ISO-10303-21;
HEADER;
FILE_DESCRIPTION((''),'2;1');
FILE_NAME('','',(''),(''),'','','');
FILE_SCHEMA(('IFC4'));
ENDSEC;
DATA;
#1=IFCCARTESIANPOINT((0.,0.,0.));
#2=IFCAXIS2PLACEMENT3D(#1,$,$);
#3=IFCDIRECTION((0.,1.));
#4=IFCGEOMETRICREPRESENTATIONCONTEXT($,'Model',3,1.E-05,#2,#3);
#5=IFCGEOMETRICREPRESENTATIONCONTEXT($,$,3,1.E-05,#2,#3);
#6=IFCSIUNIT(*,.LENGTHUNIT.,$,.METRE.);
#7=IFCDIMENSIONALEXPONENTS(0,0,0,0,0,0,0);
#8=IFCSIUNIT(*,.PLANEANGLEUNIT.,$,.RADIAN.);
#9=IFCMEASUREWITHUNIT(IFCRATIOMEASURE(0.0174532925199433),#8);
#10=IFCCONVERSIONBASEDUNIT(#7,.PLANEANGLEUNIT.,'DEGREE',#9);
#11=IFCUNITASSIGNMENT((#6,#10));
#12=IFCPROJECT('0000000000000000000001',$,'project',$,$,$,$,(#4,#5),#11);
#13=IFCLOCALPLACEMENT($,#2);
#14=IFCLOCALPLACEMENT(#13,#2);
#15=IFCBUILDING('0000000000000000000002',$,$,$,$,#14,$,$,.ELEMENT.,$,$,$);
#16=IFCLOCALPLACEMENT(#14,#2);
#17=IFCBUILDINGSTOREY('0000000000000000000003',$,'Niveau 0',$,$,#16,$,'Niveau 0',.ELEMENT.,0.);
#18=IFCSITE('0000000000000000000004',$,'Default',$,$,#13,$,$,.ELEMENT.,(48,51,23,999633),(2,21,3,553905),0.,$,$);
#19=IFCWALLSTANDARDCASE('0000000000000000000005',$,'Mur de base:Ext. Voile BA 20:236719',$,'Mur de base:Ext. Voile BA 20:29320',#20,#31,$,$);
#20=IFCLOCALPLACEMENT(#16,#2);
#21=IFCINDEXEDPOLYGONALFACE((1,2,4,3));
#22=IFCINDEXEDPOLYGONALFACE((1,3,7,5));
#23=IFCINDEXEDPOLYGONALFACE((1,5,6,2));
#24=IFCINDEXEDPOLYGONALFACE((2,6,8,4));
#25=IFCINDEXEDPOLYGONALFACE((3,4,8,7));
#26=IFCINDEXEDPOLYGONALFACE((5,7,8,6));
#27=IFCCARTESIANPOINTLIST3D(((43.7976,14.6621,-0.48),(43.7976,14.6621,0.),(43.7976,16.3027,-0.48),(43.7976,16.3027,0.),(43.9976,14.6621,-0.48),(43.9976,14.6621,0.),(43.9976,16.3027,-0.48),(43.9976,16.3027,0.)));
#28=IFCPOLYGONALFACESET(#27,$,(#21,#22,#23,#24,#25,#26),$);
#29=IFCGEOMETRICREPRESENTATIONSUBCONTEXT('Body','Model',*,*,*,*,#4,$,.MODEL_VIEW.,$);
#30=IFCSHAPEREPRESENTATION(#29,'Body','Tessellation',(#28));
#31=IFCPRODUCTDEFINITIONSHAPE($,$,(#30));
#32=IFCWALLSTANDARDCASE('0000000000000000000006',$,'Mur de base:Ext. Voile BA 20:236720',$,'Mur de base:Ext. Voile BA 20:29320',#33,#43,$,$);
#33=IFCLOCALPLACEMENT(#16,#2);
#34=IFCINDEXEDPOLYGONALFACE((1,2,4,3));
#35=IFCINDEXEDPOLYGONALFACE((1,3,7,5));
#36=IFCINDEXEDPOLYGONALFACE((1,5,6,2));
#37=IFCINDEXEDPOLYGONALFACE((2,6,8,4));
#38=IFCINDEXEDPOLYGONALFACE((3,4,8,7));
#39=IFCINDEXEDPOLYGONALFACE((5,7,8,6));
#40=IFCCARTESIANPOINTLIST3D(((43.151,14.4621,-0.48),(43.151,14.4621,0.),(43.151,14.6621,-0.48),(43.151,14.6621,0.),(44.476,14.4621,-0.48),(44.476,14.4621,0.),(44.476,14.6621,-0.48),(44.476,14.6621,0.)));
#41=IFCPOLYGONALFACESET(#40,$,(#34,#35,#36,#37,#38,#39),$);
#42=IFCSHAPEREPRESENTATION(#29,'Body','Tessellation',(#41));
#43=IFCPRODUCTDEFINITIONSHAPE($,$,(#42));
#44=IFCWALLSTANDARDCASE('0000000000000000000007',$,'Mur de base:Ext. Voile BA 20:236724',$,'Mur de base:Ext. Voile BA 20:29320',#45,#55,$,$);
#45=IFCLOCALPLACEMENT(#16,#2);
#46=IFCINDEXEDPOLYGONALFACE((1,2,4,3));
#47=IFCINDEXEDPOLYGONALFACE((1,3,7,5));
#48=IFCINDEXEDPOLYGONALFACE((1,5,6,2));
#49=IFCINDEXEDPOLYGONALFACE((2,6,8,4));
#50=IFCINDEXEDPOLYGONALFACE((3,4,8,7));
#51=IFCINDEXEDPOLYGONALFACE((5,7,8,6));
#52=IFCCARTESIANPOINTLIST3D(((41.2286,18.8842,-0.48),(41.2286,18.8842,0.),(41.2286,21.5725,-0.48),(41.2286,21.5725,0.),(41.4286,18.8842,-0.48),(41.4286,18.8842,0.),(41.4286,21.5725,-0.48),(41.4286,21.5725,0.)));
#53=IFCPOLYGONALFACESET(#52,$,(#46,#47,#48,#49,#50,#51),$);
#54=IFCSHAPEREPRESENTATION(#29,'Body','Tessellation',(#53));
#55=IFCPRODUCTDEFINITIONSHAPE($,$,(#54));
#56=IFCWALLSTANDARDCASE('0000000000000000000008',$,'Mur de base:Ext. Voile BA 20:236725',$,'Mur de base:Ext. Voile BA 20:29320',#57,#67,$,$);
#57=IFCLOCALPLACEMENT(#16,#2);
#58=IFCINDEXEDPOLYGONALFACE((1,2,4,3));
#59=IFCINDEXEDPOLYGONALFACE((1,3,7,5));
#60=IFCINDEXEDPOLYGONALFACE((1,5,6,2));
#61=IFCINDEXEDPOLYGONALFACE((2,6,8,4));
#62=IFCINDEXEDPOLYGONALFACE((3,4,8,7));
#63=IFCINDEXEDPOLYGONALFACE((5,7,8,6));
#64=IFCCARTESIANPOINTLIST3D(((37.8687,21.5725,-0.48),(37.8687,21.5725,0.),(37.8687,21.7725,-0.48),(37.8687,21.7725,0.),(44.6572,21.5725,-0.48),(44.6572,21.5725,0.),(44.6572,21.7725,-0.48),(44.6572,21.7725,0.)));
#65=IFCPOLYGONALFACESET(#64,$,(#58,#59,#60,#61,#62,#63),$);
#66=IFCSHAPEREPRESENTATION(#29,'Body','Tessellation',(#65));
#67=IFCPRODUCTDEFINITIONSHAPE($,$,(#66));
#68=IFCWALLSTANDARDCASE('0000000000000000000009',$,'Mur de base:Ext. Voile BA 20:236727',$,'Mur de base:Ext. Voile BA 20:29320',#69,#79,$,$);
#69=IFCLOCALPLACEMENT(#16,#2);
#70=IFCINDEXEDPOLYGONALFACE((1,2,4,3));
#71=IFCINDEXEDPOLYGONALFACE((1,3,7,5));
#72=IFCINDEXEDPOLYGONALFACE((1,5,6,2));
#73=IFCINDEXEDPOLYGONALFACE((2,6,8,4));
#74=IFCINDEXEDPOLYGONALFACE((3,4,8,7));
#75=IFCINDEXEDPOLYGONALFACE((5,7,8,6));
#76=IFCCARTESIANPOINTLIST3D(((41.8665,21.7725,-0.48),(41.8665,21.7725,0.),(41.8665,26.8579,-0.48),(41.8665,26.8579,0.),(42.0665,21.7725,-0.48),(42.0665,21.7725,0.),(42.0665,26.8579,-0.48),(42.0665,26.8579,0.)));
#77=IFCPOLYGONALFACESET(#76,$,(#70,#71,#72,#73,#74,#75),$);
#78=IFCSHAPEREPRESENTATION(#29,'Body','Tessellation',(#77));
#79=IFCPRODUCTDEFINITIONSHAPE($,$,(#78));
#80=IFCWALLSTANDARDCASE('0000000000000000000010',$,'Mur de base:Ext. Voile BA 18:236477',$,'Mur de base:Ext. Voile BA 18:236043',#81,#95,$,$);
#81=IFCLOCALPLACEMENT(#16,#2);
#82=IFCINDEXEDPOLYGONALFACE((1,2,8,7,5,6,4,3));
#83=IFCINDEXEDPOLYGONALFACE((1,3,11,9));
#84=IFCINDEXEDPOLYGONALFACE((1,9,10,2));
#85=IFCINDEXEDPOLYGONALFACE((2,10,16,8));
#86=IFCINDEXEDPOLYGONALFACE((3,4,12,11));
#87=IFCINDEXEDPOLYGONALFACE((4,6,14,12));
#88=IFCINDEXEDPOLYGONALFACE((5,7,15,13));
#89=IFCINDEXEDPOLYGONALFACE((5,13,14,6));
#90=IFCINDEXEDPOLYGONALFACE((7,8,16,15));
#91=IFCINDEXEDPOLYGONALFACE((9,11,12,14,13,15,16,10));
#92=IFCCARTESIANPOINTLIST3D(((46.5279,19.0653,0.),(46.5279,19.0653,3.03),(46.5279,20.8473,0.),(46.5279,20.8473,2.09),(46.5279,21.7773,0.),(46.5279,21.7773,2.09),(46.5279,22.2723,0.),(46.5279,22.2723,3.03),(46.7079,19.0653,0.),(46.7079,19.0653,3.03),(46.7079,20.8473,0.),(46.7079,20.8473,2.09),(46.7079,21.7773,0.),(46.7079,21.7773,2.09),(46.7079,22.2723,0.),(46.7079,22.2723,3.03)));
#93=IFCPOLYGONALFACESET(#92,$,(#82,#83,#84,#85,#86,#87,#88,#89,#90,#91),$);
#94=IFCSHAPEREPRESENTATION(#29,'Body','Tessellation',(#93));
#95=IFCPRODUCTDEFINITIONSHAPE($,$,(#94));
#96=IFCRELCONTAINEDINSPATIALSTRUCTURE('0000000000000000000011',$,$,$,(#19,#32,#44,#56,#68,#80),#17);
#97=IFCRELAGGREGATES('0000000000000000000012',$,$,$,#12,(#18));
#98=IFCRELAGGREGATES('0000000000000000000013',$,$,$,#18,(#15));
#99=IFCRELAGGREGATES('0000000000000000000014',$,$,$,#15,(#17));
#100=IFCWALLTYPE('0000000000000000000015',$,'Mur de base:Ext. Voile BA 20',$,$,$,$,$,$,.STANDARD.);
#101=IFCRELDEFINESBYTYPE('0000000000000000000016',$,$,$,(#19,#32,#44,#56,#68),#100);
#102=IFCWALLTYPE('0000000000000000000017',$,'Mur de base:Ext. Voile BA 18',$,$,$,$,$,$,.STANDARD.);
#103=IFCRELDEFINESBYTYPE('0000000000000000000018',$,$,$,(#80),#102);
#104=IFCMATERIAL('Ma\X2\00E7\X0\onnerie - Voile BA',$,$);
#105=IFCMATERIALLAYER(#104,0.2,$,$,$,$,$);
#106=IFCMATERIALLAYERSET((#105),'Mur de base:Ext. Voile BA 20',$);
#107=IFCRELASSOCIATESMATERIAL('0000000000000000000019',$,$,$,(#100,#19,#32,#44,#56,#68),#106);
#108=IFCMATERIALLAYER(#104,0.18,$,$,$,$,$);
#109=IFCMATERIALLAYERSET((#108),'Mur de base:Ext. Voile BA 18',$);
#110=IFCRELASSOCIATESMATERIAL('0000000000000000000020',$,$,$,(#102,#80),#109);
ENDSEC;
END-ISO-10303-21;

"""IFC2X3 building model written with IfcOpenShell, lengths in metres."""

from ifc_helpers import new_model, entity, si_unit, converted_unit, direction, frame, frame_2d, origin, place, context, subcontext, project, spatial, rectangle, extrude, material, layer, layer_set, layer_usage, type_object, element, save


model = new_model("IFC2X3")

# Units and contexts
model_context = context("Model", 3, precision=1e-05, world=origin(), true_north=direction((0.0, 1.0)))
context_of_model = context(None, 3, precision=1e-05, world=origin(), true_north=direction((0.0, 1.0)))
body_context = subcontext(model_context, "Body", "Model", "MODEL_VIEW")
ifc_project = project(units=[si_unit("LENGTHUNIT", "METRE"), converted_unit("PLANEANGLEUNIT", "DEGREE", entity("IfcRatioMeasure", 0.0174532925199433), si_unit("PLANEANGLEUNIT", "RADIAN"), dimensions=[0, 0, 0, 0, 0, 0, 0])], contexts=[model_context, context_of_model])

# Site, building, storey
site_placement = place(None, origin())
site = spatial("IfcSite", under=ifc_project, at=site_placement, Name="Default", CompositionType="ELEMENT", RefLatitude=(48, 51, 23, 999633), RefLongitude=(2, 21, 3, 553905), RefElevation=0.0)
building_placement = place(site_placement, origin())
building = spatial("IfcBuilding", under=site, at=building_placement, CompositionType="ELEMENT")
storey_placement = place(building_placement, origin())
storey = spatial("IfcBuildingStorey", under=building, at=storey_placement, Name="Niveau 0", LongName="Niveau 0", CompositionType="ELEMENT", Elevation=0.0)

# Shared definitions
ifc_material = material(Name="Maçonnerie - Voile BA")
ifc_layer_1 = layer(ifc_material, 0.2)
ifc_layer_set_1 = layer_set([ifc_layer_1], Name="Mur de base:Ext. Voile BA 20")
wall_type_1 = type_object("IfcWallType", Name="Mur de base:Ext. Voile BA 20", PredefinedType="STANDARD", material=ifc_layer_set_1)

# Walls
ifc_layer_usage_1 = layer_usage(ifc_layer_set_1, "AXIS2", "NEGATIVE", 0.1)
wall_1_placement = place(storey_placement, frame((43.8976, 14.6621, -0.48), z_axis=(0.0, 0.0, 1.0), x_axis=(0.0, 1.0, 0.0)))
element("IfcWallStandardCase", 1, at=wall_1_placement, inside=storey, type_object=wall_type_1, material=ifc_layer_usage_1, Name="Mur de base:Ext. Voile BA 20:236719", ObjectType="Mur de base:Ext. Voile BA 20:29320", context=body_context, shape_type="SweptSolid", body=[
    extrude(rectangle(XDim=1.6405, YDim=0.2, at=frame_2d((0.8203, 0.0), x_axis=(-1.0, 0.0))), origin(), (0.0, 0.0, 1.0), 0.48),
])
ifc_layer_usage_2 = layer_usage(ifc_layer_set_1, "AXIS2", "NEGATIVE", 0.1)
wall_2_placement = place(storey_placement, frame((44.476, 14.5621, -0.48), z_axis=(0.0, 0.0, 1.0), x_axis=(-1.0, 0.0, 0.0)))
element("IfcWallStandardCase", 2, at=wall_2_placement, inside=storey, type_object=wall_type_1, material=ifc_layer_usage_2, Name="Mur de base:Ext. Voile BA 20:236720", ObjectType="Mur de base:Ext. Voile BA 20:29320", context=body_context, shape_type="SweptSolid", body=[
    extrude(rectangle(XDim=1.325, YDim=0.2, at=frame_2d((0.6625, 0.0), x_axis=(-1.0, 0.0))), origin(), (0.0, 0.0, 1.0), 0.48),
])
ifc_layer_usage_3 = layer_usage(ifc_layer_set_1, "AXIS2", "NEGATIVE", 0.1)
wall_3_placement = place(storey_placement, frame((41.3286, 18.8842, -0.48), z_axis=(0.0, 0.0, 1.0), x_axis=(0.0, 1.0, 0.0)))
element("IfcWallStandardCase", 3, at=wall_3_placement, inside=storey, type_object=wall_type_1, material=ifc_layer_usage_3, Name="Mur de base:Ext. Voile BA 20:236724", ObjectType="Mur de base:Ext. Voile BA 20:29320", context=body_context, shape_type="SweptSolid", body=[
    extrude(rectangle(XDim=2.6882, YDim=0.2, at=frame_2d((1.3441, 0.0), x_axis=(-1.0, 0.0))), origin(), (0.0, 0.0, 1.0), 0.48),
])
ifc_layer_usage_4 = layer_usage(ifc_layer_set_1, "AXIS2", "NEGATIVE", 0.1)
wall_4_placement = place(storey_placement, frame((44.6572, 21.6725, -0.48), z_axis=(0.0, 0.0, 1.0), x_axis=(-1.0, 0.0, 0.0)))
element("IfcWallStandardCase", 4, at=wall_4_placement, inside=storey, type_object=wall_type_1, material=ifc_layer_usage_4, Name="Mur de base:Ext. Voile BA 20:236725", ObjectType="Mur de base:Ext. Voile BA 20:29320", context=body_context, shape_type="SweptSolid", body=[
    extrude(rectangle(XDim=6.7885, YDim=0.2, at=frame_2d((3.3943, 0.0), x_axis=(-1.0, 0.0))), origin(), (0.0, 0.0, 1.0), 0.48),
])
ifc_layer_usage_5 = layer_usage(ifc_layer_set_1, "AXIS2", "NEGATIVE", 0.1)
wall_5_placement = place(storey_placement, frame((41.9665, 21.7725, -0.48), z_axis=(0.0, 0.0, 1.0), x_axis=(0.0, 1.0, 0.0)))
element("IfcWallStandardCase", 5, at=wall_5_placement, inside=storey, type_object=wall_type_1, material=ifc_layer_usage_5, Name="Mur de base:Ext. Voile BA 20:236727", ObjectType="Mur de base:Ext. Voile BA 20:29320", context=body_context, shape_type="SweptSolid", body=[
    extrude(rectangle(XDim=5.0854, YDim=0.2, at=frame_2d((2.5427, 0.0), x_axis=(-1.0, 0.0))), origin(), (0.0, 0.0, 1.0), 0.48),
])

# Wall, opening
ifc_layer_2 = layer(ifc_material, 0.18)
ifc_layer_set_2 = layer_set([ifc_layer_2], Name="Mur de base:Ext. Voile BA 18")
ifc_layer_usage_6 = layer_usage(ifc_layer_set_2, "AXIS2", "NEGATIVE", 0.09)
wall_type_2 = type_object("IfcWallType", Name="Mur de base:Ext. Voile BA 18", PredefinedType="STANDARD", material=ifc_layer_set_2)
wall_6_placement = place(storey_placement, frame((46.6179, 19.0653, 0.0), z_axis=(0.0, 0.0, 1.0), x_axis=(0.0, 1.0, 0.0)))
wall_6 = element("IfcWallStandardCase", 6, at=wall_6_placement, inside=storey, type_object=wall_type_2, material=ifc_layer_usage_6, Name="Mur de base:Ext. Voile BA 18:236477", ObjectType="Mur de base:Ext. Voile BA 18:236043", context=body_context, shape_type="SweptSolid", body=[
    extrude(rectangle(XDim=3.207, YDim=0.18, at=frame_2d((1.6035, 0.0), x_axis=(-1.0, 0.0))), origin(), (0.0, 0.0, 1.0), 3.03),
])
opening_1_placement = place(wall_6_placement, origin())
element("IfcOpeningElement", 7, at=opening_1_placement, cuts=wall_6, ObjectType="Opening", context=body_context, shape_type="SweptSolid", body=[
    extrude(rectangle(XDim=2.09, YDim=0.93, at=frame_2d((0.0, 0.0), x_axis=(1.0, 0.0))), frame((2.247, -0.09, 1.045), z_axis=(0.0, 1.0, 0.0), x_axis=(0.0, 0.0, -1.0)), (0.0, 0.0, 1.0), 0.18),
])

save(model, "model.ifc")
